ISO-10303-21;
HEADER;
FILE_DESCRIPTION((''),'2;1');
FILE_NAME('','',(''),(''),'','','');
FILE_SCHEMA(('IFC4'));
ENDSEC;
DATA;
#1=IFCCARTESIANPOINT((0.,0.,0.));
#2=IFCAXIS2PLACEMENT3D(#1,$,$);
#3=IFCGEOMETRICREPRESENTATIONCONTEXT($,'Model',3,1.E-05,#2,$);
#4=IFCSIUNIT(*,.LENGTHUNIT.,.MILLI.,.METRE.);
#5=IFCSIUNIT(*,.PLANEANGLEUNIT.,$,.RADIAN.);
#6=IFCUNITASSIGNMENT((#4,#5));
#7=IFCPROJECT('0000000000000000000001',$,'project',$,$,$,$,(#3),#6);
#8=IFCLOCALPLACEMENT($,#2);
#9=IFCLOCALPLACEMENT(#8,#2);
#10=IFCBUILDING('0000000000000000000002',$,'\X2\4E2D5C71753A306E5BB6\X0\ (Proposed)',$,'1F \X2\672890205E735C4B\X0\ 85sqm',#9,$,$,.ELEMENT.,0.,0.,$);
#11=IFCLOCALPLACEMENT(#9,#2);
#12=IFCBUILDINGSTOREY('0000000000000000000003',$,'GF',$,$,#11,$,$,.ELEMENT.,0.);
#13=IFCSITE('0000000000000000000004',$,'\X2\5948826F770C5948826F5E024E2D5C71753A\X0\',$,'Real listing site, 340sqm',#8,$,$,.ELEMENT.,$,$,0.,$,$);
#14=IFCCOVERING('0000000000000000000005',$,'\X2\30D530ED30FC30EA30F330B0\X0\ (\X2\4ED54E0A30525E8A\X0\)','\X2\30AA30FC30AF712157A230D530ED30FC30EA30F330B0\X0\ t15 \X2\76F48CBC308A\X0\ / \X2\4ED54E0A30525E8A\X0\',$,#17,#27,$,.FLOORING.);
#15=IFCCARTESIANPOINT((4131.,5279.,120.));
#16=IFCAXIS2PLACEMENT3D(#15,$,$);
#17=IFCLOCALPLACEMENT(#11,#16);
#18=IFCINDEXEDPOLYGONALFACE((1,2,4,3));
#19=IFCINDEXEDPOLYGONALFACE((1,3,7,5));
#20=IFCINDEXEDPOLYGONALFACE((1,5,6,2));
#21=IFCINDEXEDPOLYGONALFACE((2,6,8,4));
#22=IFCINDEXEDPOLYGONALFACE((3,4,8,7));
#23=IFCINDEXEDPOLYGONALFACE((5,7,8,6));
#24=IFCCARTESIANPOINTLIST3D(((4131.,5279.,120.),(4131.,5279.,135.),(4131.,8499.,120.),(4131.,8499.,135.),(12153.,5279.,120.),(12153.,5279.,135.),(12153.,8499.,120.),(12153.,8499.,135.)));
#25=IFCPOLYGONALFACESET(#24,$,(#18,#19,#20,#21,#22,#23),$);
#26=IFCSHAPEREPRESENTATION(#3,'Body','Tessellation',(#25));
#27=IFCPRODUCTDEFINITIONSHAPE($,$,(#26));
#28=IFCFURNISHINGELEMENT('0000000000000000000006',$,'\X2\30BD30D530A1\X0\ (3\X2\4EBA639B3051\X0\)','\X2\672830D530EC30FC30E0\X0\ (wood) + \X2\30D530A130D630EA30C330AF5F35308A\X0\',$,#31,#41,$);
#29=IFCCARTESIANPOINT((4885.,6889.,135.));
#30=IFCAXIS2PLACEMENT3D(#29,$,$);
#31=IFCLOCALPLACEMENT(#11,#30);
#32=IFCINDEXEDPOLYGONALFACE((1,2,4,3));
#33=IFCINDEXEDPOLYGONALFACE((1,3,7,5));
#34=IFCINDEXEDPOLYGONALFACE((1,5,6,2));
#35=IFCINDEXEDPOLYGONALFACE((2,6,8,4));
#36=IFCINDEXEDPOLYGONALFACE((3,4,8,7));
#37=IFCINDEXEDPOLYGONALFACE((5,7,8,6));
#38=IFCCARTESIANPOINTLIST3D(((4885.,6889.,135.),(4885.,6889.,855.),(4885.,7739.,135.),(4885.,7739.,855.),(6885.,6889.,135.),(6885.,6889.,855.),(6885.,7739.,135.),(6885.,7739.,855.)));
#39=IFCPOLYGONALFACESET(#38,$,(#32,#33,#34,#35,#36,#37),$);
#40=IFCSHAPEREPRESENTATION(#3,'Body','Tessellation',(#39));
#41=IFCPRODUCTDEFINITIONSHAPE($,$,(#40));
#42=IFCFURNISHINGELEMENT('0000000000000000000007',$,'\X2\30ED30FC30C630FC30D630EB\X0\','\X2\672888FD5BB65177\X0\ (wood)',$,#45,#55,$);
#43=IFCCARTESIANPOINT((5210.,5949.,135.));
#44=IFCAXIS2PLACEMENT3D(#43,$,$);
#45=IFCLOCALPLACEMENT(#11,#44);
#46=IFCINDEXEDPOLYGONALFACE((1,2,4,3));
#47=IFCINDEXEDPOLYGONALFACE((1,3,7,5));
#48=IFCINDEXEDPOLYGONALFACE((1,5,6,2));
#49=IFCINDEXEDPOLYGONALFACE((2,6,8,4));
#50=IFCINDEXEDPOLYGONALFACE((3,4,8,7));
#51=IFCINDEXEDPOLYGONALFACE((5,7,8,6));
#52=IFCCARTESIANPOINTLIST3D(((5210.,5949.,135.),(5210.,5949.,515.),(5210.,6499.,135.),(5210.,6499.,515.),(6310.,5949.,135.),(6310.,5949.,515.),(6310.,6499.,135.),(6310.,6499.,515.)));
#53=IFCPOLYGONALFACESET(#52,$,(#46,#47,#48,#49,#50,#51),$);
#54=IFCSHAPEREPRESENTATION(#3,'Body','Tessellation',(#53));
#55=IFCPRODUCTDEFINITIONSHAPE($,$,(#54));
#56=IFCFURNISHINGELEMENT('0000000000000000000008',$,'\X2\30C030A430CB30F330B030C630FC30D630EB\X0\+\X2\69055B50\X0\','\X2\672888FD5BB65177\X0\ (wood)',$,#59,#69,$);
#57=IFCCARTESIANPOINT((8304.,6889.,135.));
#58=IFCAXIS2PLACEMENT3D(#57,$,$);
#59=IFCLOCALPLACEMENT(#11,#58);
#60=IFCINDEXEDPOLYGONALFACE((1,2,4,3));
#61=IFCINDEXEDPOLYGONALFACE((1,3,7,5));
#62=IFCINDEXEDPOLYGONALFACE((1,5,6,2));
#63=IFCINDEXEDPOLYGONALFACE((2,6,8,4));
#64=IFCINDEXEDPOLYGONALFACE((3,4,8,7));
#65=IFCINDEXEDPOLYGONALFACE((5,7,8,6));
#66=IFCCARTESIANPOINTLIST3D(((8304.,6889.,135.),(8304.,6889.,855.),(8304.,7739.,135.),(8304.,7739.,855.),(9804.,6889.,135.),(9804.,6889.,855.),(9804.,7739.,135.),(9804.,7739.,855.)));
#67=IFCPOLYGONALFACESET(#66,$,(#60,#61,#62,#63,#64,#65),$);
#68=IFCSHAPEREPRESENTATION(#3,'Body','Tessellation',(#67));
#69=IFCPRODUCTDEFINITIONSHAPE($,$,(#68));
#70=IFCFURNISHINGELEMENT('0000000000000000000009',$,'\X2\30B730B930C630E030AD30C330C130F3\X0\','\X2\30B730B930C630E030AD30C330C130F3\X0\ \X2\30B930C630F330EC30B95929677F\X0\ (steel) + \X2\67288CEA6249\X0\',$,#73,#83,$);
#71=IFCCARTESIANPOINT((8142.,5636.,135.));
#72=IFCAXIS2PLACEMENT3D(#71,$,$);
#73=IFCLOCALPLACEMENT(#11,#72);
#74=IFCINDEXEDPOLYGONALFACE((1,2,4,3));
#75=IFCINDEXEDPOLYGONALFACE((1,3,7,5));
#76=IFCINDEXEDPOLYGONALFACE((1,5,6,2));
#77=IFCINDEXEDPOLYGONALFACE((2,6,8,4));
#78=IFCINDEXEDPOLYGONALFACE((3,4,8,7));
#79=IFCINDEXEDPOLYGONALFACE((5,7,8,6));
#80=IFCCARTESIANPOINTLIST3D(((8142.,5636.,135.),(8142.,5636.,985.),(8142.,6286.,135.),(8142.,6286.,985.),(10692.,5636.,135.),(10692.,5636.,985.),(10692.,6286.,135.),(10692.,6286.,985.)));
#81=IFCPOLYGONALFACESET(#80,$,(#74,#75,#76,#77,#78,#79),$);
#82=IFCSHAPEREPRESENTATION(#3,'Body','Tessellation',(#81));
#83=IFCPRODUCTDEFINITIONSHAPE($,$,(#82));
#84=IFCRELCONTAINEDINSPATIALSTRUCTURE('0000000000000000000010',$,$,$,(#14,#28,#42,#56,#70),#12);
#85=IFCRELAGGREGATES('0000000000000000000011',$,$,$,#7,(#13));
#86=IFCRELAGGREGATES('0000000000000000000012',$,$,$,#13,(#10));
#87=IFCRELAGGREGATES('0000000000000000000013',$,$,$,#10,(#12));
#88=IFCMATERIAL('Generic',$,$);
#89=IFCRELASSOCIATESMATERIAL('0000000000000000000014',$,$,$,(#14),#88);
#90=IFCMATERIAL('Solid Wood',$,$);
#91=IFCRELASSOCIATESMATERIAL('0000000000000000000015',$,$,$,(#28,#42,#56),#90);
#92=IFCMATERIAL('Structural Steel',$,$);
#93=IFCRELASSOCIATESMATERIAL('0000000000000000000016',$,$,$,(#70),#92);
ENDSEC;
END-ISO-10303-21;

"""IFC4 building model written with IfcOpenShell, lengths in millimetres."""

from ifc_helpers import new_model, si_unit, frame, frame_2d, origin, place, context, project, spatial, rectangle, extrude, material, element, save


model = new_model("IFC4")

# Units and contexts
model_context = context("Model", 3, precision=1e-05, world=origin())
ifc_project = project(units=[si_unit("LENGTHUNIT", "METRE", prefix="MILLI"), si_unit("PLANEANGLEUNIT", "RADIAN")], contexts=[model_context])

# Site, building, storey
site_placement = place(None, origin())
site = spatial("IfcSite", under=ifc_project, at=site_placement, Name="奈良県奈良市中山町", ObjectType="Real listing site, 340sqm", CompositionType="ELEMENT", RefElevation=0.0)
building_placement = place(site_placement, origin())
building = spatial("IfcBuilding", under=site, at=building_placement, Name="中山町の家 (Proposed)", ObjectType="1F 木造平屋 85sqm", CompositionType="ELEMENT", ElevationOfRefHeight=0.0, ElevationOfTerrain=0.0)
storey_placement = place(building_placement, origin())
storey = spatial("IfcBuildingStorey", under=building, at=storey_placement, Name="GF", CompositionType="ELEMENT", Elevation=0.0)

# Shared definitions
ifc_material_1 = material(Name="Solid Wood")

# Shared definitions
ifc_material_2 = material(Name="Structural Steel")

# Covering
ifc_material_3 = material(Name="Generic")
covering_placement = place(storey_placement, frame((4131.0, 5279.0, 120.0)))
element("IfcCovering", 1, at=covering_placement, inside=storey, material=ifc_material_3, Name="フローリング (仕上げ床)", Description="オーク無垢フローリング t15 直貼り / 仕上げ床", PredefinedType="FLOORING", context=model_context, shape_type="SweptSolid", body=[
    extrude(rectangle(XDim=8022.0, YDim=3220.0, at=frame_2d((4011.0, 1610.0))), frame((4131.0, 5279.0, 120.0)), (0.0, 0.0, 1.0), 15.0),
])

# Furnishing elements
furnishing_1_placement = place(storey_placement, frame((4885.0, 6889.0, 135.0)))
element("IfcFurnishingElement", 2, at=furnishing_1_placement, inside=storey, material=ifc_material_1, Name="ソファ (3人掛け)", Description="木フレーム (wood) + ファブリック張り", context=model_context, shape_type="SweptSolid", body=[
    extrude(rectangle(XDim=2000.0, YDim=850.0, at=frame_2d((1000.0, 425.0))), frame((4885.0, 6889.0, 135.0)), (0.0, 0.0, 1.0), 720.0),
])
furnishing_2_placement = place(storey_placement, frame((5210.0, 5949.0, 135.0)))
element("IfcFurnishingElement", 3, at=furnishing_2_placement, inside=storey, material=ifc_material_1, Name="ローテーブル", Description="木製家具 (wood)", context=model_context, shape_type="SweptSolid", body=[
    extrude(rectangle(XDim=1100.0, YDim=550.0, at=frame_2d((550.0, 275.0))), frame((5210.0, 5949.0, 135.0)), (0.0, 0.0, 1.0), 380.0),
])
furnishing_3_placement = place(storey_placement, frame((8304.0, 6889.0, 135.0)))
element("IfcFurnishingElement", 4, at=furnishing_3_placement, inside=storey, material=ifc_material_1, Name="ダイニングテーブル+椅子", Description="木製家具 (wood)", context=model_context, shape_type="SweptSolid", body=[
    extrude(rectangle(XDim=1500.0, YDim=850.0, at=frame_2d((750.0, 425.0))), frame((8304.0, 6889.0, 135.0)), (0.0, 0.0, 1.0), 720.0),
])
furnishing_4_placement = place(storey_placement, frame((8142.0, 5636.0, 135.0)))
element("IfcFurnishingElement", 5, at=furnishing_4_placement, inside=storey, material=ifc_material_2, Name="システムキッチン", Description="システムキッチン ステンレス天板 (steel) + 木質扉", context=model_context, shape_type="SweptSolid", body=[
    extrude(rectangle(XDim=2550.0, YDim=650.0, at=frame_2d((1275.0, 325.0))), frame((8142.0, 5636.0, 135.0)), (0.0, 0.0, 1.0), 850.0),
])

save(model, "model.ifc")
